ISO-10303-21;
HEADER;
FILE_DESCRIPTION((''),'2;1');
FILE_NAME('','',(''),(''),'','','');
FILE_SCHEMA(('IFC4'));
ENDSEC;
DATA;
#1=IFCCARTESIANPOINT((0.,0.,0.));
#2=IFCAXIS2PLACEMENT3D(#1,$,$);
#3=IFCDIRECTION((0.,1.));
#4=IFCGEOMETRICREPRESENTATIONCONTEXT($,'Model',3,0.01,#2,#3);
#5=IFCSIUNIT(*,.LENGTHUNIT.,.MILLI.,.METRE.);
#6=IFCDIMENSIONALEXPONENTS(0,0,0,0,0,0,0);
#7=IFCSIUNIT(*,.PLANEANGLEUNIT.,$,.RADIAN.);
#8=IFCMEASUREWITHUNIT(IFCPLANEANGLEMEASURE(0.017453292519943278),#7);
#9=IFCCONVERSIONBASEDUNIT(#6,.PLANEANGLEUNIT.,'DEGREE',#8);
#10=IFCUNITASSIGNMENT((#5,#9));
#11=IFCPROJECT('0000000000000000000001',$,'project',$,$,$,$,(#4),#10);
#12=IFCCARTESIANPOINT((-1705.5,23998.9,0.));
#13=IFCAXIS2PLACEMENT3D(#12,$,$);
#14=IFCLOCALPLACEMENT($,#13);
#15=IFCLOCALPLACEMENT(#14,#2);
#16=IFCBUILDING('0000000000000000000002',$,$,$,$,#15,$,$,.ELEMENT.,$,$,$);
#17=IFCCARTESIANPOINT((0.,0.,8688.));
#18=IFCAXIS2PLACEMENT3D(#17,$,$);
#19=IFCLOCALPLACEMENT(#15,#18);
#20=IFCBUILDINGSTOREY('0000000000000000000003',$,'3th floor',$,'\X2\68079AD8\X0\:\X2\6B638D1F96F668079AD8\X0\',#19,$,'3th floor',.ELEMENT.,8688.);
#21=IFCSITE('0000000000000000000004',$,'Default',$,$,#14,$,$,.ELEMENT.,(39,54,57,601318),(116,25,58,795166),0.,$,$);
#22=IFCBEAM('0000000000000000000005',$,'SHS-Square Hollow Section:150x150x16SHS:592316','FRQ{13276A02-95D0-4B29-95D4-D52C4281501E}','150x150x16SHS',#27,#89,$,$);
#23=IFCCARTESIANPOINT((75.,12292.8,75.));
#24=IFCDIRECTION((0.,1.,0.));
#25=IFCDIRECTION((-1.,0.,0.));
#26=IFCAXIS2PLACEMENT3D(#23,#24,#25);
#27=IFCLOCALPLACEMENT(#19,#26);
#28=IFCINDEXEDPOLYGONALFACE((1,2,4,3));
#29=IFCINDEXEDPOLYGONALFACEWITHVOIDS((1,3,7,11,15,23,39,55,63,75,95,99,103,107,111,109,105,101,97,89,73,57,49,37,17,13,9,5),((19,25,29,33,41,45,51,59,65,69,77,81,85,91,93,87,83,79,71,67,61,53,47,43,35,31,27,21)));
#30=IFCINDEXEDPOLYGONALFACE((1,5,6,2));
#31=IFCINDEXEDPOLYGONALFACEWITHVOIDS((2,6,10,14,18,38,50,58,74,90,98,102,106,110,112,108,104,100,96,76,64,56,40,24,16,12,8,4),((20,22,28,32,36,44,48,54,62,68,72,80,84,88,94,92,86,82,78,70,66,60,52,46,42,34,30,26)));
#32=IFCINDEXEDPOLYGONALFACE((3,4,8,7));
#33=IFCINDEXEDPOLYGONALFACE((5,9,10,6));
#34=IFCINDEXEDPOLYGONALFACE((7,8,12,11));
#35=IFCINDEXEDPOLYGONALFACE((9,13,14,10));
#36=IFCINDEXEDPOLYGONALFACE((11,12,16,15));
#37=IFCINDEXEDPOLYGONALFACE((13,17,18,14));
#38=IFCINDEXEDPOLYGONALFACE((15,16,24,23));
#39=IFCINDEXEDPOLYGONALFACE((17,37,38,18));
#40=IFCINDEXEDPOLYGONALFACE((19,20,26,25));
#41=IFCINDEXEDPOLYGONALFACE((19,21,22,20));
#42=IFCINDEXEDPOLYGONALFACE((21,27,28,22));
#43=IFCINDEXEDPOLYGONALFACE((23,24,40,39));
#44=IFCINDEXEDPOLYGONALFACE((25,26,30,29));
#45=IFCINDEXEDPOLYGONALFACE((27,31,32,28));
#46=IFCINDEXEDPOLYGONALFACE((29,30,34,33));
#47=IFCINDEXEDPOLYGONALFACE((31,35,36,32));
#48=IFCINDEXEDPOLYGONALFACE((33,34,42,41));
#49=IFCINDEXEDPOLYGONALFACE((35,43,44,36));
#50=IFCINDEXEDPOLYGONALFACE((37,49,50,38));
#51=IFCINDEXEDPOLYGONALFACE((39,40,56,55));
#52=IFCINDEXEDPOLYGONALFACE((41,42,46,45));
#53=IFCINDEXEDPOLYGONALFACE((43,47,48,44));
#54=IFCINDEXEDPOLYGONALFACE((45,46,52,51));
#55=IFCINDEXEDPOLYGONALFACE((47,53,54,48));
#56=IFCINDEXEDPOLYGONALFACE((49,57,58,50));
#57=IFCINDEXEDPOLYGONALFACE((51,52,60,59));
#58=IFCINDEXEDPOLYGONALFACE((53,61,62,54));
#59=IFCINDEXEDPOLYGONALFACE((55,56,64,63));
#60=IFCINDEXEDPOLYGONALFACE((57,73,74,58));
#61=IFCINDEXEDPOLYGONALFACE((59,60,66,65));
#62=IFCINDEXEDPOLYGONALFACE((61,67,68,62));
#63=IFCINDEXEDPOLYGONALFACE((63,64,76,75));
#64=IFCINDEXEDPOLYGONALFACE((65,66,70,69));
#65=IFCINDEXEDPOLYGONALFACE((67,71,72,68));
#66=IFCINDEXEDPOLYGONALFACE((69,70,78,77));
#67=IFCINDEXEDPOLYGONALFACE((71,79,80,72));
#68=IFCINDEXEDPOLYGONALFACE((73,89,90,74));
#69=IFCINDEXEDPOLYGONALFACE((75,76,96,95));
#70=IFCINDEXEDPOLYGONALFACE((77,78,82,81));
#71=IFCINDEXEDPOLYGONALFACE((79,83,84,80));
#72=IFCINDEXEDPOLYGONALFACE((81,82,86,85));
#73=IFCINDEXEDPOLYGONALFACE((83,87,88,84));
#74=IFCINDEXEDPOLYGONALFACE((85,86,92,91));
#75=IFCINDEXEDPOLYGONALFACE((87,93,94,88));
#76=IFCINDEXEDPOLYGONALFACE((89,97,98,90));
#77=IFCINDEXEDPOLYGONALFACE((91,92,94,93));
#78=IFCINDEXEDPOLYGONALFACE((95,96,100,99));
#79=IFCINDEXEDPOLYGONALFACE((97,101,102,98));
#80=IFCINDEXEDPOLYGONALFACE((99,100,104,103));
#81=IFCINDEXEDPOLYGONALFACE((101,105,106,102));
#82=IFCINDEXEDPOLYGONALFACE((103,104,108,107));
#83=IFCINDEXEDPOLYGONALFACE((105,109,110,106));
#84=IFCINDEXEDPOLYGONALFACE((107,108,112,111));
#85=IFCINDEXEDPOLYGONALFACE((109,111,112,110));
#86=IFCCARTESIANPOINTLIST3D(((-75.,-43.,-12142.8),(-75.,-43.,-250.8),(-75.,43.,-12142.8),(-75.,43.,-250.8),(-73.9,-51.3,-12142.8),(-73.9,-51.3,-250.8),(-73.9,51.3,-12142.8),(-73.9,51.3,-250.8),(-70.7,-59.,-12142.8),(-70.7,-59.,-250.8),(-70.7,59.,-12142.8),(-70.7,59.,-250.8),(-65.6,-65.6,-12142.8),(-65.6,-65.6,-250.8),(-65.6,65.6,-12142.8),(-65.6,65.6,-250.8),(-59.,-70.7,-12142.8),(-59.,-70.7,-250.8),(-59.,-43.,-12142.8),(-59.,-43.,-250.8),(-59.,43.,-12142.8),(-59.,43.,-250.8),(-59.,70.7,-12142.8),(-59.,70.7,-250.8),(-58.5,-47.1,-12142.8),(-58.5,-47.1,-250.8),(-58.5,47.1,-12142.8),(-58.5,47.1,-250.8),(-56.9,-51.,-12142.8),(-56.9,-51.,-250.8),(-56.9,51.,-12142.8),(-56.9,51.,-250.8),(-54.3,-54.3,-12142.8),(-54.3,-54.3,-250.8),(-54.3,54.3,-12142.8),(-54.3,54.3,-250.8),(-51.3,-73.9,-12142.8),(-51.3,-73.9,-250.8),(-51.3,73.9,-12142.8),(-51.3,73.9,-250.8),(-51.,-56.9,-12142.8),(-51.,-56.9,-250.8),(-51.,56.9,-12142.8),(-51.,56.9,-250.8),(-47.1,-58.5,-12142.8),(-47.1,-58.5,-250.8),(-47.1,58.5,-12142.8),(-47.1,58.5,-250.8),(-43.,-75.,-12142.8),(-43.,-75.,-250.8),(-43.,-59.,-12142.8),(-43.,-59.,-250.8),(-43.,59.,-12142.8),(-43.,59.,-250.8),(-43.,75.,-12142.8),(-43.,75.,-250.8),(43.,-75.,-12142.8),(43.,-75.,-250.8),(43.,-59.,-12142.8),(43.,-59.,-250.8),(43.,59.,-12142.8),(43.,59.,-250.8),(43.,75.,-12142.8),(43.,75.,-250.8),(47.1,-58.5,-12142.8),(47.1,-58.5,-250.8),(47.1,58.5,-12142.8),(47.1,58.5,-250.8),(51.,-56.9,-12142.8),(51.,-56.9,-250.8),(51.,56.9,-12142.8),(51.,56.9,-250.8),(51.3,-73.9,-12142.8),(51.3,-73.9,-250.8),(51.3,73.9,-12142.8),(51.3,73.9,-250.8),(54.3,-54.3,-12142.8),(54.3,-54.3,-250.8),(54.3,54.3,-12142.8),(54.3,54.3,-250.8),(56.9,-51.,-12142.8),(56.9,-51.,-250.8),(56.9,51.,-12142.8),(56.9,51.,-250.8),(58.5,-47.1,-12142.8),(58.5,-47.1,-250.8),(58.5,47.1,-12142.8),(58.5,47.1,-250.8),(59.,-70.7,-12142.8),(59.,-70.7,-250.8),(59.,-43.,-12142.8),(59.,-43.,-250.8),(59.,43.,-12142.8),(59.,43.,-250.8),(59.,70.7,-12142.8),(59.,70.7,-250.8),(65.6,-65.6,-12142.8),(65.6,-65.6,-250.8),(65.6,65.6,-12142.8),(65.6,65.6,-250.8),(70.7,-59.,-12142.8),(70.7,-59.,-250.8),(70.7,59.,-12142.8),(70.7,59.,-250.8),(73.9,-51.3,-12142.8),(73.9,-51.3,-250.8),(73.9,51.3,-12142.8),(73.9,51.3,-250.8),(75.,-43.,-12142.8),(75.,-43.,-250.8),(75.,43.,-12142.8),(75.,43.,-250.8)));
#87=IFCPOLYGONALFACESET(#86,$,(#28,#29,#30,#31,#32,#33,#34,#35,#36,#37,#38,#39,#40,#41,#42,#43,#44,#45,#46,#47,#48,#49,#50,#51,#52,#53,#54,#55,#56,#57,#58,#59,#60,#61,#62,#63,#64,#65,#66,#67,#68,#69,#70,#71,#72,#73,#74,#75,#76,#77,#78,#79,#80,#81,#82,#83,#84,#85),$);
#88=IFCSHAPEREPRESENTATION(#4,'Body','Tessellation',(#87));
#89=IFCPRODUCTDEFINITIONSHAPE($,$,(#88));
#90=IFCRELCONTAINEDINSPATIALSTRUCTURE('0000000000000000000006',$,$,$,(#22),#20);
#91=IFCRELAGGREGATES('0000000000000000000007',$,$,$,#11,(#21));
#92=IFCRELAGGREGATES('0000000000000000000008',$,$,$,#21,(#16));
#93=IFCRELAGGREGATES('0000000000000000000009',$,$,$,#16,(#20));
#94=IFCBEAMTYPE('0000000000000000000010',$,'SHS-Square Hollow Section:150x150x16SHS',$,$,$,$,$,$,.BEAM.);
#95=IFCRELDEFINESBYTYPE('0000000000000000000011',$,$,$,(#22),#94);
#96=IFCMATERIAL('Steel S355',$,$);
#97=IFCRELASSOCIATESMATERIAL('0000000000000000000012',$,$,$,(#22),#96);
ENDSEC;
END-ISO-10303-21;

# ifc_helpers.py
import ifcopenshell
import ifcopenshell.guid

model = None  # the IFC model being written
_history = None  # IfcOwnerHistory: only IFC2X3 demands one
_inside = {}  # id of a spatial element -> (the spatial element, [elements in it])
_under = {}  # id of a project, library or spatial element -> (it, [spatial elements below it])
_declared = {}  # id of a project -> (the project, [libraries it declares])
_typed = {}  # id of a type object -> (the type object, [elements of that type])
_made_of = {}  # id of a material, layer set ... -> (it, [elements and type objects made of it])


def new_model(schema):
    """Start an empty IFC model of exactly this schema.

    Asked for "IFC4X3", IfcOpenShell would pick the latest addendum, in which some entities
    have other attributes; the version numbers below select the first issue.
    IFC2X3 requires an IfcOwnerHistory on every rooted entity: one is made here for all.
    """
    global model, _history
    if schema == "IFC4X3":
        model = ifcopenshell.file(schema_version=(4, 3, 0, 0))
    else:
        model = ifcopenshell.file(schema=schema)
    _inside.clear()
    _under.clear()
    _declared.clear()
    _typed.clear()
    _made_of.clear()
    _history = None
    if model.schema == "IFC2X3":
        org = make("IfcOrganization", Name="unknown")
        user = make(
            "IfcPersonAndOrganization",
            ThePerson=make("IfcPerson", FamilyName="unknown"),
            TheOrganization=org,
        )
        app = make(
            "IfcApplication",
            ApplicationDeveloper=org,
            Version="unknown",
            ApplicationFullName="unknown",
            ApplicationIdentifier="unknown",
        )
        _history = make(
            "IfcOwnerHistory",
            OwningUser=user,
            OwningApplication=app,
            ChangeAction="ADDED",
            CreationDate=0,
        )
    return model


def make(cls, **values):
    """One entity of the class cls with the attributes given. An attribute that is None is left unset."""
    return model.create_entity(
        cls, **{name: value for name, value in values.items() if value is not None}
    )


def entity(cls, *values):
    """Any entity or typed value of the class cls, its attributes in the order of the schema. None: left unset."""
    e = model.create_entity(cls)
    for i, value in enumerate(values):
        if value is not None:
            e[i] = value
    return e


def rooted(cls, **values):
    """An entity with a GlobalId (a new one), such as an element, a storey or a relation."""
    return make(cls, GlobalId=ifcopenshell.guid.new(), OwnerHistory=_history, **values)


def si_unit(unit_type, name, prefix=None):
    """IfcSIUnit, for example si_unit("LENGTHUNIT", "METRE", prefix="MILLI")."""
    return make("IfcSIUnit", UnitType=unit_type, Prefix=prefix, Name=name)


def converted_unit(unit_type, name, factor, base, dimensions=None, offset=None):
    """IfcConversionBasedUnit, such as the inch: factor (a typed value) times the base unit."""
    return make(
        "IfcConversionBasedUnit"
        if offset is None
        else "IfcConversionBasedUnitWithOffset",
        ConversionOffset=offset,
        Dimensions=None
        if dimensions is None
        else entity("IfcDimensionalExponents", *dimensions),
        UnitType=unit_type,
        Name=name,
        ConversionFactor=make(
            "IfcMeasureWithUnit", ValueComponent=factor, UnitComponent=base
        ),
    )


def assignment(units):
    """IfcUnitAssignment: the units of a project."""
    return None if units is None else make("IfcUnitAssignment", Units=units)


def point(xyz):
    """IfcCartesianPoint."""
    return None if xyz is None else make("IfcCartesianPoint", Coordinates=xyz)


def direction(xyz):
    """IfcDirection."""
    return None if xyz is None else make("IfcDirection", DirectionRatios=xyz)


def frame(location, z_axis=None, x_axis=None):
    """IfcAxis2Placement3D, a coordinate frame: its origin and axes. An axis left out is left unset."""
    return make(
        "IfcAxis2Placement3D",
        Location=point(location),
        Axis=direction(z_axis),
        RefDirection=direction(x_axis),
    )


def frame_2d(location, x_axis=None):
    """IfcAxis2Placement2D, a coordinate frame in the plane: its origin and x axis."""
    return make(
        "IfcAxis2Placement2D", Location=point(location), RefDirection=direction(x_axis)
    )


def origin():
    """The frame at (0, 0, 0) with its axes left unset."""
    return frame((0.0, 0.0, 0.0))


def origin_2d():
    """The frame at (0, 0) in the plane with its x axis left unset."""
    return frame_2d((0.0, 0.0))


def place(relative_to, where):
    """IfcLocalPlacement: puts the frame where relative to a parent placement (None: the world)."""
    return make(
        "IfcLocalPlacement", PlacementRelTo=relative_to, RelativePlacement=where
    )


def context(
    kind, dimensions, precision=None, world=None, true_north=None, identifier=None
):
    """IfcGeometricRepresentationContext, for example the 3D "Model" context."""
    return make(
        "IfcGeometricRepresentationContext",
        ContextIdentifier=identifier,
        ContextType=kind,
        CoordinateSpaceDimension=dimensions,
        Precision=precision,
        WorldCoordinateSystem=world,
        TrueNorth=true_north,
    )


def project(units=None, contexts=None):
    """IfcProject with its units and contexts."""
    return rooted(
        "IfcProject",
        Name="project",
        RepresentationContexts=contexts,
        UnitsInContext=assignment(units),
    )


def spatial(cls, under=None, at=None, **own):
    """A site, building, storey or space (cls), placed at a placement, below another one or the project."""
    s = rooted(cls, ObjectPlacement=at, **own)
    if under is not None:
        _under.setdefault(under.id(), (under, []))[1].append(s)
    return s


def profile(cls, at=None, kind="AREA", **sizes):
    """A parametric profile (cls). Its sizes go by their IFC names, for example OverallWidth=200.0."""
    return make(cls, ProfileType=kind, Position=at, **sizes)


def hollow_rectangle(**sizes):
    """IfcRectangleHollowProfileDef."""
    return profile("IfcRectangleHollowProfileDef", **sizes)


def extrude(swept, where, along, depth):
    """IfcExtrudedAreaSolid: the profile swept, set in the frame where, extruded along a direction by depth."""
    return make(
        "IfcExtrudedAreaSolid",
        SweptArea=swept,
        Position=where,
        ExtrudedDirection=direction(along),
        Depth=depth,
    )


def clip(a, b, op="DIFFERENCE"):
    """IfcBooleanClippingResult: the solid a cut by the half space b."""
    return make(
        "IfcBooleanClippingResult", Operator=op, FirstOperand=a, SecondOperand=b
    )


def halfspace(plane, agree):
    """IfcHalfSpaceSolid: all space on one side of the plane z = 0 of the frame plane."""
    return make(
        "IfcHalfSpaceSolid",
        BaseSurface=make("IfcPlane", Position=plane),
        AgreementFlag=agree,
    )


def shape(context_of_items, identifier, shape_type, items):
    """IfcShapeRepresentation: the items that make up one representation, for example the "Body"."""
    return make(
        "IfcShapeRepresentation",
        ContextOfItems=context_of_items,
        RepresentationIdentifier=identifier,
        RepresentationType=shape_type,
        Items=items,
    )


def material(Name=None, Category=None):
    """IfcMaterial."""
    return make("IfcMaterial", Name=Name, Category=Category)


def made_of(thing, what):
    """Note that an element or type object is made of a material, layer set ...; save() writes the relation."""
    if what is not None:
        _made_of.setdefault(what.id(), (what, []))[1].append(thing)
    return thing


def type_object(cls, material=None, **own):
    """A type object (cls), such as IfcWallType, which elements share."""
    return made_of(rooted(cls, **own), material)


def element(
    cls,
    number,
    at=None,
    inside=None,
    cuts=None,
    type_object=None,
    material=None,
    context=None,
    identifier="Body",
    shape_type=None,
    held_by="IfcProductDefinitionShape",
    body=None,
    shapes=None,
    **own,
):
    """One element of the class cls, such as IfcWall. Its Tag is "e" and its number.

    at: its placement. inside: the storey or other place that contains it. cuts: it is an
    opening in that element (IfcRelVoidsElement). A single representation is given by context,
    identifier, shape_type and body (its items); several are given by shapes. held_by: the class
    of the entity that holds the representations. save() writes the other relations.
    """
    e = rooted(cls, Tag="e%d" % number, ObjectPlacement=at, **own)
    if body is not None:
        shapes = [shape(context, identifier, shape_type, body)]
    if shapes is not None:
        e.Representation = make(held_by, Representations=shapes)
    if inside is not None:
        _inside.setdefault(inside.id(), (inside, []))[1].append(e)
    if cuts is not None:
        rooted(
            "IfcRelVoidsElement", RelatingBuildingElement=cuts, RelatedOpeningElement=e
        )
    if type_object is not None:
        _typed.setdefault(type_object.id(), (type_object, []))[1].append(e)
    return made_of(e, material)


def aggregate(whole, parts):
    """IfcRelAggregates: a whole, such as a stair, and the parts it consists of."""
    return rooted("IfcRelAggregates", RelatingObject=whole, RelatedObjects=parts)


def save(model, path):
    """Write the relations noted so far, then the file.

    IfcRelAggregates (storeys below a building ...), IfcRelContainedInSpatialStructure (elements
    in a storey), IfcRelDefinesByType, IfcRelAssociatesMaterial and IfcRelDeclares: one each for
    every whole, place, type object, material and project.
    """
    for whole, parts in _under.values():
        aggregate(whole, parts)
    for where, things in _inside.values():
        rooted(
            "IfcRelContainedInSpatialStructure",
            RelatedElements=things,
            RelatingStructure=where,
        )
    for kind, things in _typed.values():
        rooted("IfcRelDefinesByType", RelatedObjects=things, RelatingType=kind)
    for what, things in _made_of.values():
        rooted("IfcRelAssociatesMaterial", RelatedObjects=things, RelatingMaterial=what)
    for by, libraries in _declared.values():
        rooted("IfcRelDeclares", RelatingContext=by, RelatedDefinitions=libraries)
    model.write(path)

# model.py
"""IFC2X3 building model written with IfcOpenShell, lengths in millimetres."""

from ifc_helpers import new_model, entity, si_unit, converted_unit, direction, frame, origin, origin_2d, place, context, project, spatial, hollow_rectangle, extrude, clip, halfspace, material, type_object, element, save


model = new_model("IFC2X3")

# Units and contexts
model_context = context("Model", 3, precision=0.01, world=origin(), true_north=direction((0.0, 1.0)))
ifc_project = project(units=[si_unit("LENGTHUNIT", "METRE", prefix="MILLI"), converted_unit("PLANEANGLEUNIT", "DEGREE", entity("IfcPlaneAngleMeasure", 0.017453292519943278), si_unit("PLANEANGLEUNIT", "RADIAN"), dimensions=[0, 0, 0, 0, 0, 0, 0])], contexts=[model_context])

# Site, building, storey
site_placement = place(None, frame((-1705.5, 23998.9, 0.0)))
site = spatial("IfcSite", under=ifc_project, at=site_placement, Name="Default", CompositionType="ELEMENT", RefLatitude=(39, 54, 57, 601318), RefLongitude=(116, 25, 58, 795166), RefElevation=0.0)
building_placement = place(site_placement, origin())
building = spatial("IfcBuilding", under=site, at=building_placement, CompositionType="ELEMENT")
storey_placement = place(building_placement, frame((0.0, 0.0, 8688.0)))
storey = spatial("IfcBuildingStorey", under=building, at=storey_placement, Name="3th floor", ObjectType="标高:正负零标高", LongName="3th floor", CompositionType="ELEMENT", Elevation=8688.0)

# Shared definitions
ifc_material_1 = material(Name="Steel S355")

# Beam
beam_type_1 = type_object("IfcBeamType", Name="SHS-Square Hollow Section:150x150x16SHS", PredefinedType="BEAM")
beam_1_placement = place(storey_placement, frame((75.0, 12292.8, 75.0), z_axis=(0.0, 1.0, 0.0), x_axis=(-1.0, 0.0, 0.0)))
element("IfcBeam", 1, at=beam_1_placement, inside=storey, type_object=beam_type_1, material=ifc_material_1, Name="SHS-Square Hollow Section:150x150x16SHS:592316", Description="FRQ{13276A02-95D0-4B29-95D4-D52C4281501E}", ObjectType="150x150x16SHS", context=model_context, shape_type="Clipping", body=[
    clip(clip(extrude(hollow_rectangle(XDim=150.0, YDim=150.0, WallThickness=16.0, InnerFilletRadius=16.0, OuterFilletRadius=32.0, at=origin_2d()), origin(), (0.0, 0.0, -1.0), 12398.9), halfspace(frame((75.0, -8763.0, -12142.8), z_axis=(0.0, 0.0, 1.0), x_axis=(1.0, 0.0, 0.0)), True)), halfspace(frame((75.0, -8763.0, -250.8), z_axis=(0.0, 0.0, -1.0), x_axis=(-1.0, 0.0, 0.0)), True)),
])

save(model, "model.ifc")
